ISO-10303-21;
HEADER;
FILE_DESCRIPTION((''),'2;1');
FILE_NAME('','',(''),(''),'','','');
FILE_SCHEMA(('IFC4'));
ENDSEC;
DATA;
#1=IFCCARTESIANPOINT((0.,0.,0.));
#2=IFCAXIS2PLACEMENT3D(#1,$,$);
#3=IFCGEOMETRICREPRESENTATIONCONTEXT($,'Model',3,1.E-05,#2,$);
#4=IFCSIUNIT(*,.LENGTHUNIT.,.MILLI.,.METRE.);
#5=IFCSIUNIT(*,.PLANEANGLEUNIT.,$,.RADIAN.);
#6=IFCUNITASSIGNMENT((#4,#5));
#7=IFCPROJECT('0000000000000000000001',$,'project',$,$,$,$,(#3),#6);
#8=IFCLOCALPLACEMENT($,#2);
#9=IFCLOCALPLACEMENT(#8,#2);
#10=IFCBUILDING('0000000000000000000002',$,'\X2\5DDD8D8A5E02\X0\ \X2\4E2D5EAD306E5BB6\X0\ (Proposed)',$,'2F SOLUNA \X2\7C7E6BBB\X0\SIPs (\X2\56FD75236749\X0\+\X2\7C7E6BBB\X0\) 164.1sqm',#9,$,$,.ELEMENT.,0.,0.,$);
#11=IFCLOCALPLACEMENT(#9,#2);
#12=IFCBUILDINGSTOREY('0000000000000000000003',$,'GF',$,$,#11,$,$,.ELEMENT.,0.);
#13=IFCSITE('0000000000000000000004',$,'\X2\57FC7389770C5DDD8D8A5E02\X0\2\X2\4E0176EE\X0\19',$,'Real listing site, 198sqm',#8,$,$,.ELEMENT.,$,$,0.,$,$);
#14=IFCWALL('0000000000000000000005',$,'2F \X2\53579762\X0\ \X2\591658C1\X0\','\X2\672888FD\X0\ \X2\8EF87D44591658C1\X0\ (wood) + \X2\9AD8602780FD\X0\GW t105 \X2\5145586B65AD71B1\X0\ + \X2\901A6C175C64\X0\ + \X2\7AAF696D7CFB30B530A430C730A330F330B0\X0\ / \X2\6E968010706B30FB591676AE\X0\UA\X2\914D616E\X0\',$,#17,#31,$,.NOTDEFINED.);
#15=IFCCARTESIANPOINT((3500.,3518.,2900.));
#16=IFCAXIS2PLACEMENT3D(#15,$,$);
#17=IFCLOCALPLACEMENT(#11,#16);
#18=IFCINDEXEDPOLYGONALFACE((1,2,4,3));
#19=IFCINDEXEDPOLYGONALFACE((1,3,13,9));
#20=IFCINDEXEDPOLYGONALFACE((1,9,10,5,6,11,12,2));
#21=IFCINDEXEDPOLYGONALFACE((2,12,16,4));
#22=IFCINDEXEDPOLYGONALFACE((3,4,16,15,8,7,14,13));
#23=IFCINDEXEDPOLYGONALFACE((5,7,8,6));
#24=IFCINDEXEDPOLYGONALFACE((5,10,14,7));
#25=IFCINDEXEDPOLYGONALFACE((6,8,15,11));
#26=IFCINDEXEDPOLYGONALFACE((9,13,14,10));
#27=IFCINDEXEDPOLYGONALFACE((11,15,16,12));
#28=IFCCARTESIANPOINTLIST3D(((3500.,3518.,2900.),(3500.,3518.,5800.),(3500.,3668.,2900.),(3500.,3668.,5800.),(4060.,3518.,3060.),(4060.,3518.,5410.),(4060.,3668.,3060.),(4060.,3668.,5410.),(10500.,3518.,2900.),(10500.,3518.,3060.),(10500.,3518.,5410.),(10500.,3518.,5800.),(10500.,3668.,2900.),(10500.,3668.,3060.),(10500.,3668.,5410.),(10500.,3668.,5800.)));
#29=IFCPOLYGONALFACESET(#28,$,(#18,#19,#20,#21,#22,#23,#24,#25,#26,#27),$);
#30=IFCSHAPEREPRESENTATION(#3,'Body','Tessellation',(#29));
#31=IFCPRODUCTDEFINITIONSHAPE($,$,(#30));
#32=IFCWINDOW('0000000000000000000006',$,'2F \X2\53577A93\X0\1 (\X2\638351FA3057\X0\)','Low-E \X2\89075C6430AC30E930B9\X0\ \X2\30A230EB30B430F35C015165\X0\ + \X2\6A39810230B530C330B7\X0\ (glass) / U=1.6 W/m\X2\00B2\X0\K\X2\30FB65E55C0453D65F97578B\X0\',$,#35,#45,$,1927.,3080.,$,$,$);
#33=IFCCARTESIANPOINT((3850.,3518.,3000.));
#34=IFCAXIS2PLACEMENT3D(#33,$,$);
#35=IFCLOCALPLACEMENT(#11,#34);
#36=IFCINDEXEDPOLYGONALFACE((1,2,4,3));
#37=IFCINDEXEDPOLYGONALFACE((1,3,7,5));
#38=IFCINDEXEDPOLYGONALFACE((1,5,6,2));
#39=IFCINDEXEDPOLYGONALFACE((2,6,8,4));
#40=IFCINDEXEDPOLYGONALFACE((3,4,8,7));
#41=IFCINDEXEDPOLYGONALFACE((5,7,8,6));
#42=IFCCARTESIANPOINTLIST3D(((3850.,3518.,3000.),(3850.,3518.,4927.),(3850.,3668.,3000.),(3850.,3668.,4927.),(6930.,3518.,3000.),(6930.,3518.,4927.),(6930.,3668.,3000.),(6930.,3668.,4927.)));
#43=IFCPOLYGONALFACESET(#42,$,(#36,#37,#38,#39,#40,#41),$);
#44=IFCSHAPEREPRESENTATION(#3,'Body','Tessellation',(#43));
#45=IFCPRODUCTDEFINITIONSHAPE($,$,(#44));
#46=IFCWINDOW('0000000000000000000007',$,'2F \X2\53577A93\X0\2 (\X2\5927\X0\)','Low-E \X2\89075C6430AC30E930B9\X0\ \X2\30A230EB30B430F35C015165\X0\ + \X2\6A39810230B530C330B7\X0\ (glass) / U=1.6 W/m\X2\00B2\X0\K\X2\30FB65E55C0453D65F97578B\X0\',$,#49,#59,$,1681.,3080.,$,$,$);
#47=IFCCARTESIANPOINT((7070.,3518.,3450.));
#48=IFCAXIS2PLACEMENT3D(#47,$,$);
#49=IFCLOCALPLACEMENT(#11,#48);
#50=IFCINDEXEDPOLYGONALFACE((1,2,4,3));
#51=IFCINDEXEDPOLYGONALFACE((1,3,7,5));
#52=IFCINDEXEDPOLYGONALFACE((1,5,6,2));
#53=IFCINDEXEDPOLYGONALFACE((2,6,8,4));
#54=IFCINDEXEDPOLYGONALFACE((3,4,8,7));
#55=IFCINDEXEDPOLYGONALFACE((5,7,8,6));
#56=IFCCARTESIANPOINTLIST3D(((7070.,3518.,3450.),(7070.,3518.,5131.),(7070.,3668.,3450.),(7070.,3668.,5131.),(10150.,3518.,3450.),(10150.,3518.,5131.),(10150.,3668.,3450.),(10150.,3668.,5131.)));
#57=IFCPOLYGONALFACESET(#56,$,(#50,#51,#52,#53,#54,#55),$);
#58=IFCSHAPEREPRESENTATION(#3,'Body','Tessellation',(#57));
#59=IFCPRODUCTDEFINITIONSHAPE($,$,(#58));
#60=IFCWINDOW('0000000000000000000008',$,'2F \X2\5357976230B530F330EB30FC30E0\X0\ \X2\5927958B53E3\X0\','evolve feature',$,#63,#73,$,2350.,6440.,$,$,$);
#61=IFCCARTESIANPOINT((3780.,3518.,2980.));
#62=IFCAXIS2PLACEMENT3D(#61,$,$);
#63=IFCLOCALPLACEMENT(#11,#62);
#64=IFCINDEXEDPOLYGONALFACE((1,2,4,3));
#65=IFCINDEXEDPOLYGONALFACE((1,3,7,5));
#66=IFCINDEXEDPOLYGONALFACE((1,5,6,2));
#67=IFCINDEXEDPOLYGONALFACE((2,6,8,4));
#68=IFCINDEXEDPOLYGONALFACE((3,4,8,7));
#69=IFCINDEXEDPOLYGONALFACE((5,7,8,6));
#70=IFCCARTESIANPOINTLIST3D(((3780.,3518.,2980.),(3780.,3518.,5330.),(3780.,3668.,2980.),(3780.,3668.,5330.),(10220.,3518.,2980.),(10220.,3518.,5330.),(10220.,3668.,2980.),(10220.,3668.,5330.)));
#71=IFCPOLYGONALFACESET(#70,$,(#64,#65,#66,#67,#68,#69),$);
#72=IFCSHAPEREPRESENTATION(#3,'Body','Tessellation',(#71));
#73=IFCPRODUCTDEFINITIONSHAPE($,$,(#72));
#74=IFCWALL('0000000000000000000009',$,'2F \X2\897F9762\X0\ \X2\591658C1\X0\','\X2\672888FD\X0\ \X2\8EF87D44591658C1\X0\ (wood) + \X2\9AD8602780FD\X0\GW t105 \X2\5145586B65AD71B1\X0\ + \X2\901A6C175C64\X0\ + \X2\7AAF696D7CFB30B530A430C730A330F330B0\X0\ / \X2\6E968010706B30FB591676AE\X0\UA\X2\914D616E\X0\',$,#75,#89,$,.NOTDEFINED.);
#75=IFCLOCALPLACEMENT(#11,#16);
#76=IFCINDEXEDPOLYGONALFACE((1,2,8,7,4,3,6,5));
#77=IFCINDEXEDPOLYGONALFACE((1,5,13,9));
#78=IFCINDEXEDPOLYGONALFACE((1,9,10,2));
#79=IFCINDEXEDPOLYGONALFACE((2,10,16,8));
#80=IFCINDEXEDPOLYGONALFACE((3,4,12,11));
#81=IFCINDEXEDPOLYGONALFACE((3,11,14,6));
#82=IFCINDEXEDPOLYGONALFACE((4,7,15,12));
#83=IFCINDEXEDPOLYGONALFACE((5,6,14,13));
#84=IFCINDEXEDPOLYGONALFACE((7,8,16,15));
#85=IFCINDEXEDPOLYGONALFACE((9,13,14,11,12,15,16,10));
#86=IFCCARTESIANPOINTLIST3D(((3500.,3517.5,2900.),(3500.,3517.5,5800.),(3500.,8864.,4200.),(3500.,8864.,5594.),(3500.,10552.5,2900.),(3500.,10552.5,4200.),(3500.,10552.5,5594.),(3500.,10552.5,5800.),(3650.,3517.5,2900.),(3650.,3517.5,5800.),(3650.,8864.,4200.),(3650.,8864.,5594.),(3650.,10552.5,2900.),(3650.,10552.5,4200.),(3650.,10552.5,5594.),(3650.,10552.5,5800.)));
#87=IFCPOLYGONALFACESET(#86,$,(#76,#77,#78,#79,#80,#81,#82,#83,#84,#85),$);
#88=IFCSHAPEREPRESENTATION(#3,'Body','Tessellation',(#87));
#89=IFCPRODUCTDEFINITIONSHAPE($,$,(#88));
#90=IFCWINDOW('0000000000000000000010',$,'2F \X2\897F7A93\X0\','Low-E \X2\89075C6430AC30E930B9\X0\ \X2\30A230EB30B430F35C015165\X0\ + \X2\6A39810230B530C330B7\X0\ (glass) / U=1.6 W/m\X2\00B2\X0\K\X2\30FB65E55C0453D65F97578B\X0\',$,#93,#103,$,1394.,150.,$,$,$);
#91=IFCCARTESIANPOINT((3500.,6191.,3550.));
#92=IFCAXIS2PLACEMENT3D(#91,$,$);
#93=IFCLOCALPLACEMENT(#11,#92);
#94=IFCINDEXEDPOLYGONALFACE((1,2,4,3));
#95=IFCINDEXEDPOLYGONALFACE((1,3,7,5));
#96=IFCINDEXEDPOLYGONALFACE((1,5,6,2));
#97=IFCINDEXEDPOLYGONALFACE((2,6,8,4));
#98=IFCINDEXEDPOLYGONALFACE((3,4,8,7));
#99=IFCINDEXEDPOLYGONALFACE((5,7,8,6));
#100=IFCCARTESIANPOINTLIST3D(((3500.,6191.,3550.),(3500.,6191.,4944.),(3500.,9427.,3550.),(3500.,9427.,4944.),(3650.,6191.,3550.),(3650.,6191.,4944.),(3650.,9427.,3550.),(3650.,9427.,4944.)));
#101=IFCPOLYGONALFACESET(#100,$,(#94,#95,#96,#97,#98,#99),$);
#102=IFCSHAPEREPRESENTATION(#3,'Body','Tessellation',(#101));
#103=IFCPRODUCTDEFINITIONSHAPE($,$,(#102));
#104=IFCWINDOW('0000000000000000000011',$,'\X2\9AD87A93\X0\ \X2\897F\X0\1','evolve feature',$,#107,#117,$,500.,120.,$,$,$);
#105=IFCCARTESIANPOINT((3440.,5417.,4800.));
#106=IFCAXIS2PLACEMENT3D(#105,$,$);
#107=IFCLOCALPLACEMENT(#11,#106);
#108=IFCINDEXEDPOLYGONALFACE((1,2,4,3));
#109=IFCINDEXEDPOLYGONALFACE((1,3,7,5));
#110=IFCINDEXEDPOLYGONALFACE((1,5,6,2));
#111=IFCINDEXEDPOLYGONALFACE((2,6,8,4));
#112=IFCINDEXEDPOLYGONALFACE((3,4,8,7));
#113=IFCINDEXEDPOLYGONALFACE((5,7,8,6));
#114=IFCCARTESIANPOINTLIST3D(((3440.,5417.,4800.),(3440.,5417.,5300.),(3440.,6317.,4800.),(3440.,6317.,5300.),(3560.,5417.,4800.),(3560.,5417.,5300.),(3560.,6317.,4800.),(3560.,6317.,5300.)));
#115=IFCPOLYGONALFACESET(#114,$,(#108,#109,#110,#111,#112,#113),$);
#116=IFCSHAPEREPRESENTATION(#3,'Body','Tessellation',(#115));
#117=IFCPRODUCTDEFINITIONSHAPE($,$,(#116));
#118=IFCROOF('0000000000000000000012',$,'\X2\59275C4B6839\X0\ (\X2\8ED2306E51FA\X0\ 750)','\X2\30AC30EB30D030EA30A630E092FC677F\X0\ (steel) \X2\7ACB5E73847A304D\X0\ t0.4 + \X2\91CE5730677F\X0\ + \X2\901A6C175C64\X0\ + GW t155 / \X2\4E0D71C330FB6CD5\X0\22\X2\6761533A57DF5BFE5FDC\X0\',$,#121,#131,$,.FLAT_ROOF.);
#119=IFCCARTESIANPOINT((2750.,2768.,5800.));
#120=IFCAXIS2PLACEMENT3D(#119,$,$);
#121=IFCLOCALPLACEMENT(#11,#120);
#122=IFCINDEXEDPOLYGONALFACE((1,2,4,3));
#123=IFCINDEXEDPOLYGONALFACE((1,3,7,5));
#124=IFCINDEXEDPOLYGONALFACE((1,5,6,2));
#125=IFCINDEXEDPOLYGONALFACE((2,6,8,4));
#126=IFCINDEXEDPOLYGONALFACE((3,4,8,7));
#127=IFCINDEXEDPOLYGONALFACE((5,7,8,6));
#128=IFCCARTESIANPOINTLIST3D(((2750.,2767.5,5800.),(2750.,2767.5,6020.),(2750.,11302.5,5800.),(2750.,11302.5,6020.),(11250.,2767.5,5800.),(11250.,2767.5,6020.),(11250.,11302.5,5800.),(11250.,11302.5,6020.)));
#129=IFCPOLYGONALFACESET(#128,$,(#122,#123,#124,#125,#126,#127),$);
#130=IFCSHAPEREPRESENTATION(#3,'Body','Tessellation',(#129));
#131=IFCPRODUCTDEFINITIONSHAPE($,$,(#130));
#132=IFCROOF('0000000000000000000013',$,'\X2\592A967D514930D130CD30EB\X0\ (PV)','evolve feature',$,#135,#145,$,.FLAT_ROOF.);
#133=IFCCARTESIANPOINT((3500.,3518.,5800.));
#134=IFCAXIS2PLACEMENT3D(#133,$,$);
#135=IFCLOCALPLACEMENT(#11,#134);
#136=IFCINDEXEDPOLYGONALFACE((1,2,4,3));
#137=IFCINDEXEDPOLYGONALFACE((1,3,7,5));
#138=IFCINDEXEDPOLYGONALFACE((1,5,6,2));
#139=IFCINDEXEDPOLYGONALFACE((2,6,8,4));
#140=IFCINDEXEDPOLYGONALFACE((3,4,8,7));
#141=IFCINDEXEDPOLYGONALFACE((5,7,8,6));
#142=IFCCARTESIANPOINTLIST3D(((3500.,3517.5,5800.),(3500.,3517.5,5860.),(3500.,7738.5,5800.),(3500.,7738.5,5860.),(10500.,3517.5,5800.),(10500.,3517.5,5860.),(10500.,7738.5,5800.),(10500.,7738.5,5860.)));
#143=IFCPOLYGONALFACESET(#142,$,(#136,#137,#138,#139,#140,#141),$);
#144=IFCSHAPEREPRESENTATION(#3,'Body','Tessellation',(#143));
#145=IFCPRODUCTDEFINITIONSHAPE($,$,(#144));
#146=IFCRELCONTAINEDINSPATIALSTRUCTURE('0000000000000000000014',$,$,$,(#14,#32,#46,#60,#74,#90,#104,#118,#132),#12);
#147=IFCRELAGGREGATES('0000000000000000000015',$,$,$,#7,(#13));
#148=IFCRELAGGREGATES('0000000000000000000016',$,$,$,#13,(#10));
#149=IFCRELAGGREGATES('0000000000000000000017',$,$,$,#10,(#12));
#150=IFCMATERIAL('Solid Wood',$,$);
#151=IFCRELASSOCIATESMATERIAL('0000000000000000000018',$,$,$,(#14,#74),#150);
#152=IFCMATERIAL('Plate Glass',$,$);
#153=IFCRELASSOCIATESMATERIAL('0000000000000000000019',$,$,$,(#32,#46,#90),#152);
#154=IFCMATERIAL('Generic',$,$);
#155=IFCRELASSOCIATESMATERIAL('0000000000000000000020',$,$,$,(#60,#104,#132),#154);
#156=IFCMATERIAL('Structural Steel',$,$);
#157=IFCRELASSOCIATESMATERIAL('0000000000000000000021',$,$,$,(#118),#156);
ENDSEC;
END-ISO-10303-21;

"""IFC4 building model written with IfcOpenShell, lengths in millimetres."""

from ifc_helpers import new_model, si_unit, frame, frame_2d, origin, place, context, project, spatial, rectangle, extrude, material, element, fill, save


model = new_model("IFC4")

# Units and contexts
model_context = context("Model", 3, precision=1e-05, world=origin())
ifc_project = project(units=[si_unit("LENGTHUNIT", "METRE", prefix="MILLI"), si_unit("PLANEANGLEUNIT", "RADIAN")], contexts=[model_context])

# Site, building, storey
site_placement = place(None, origin())
site = spatial("IfcSite", under=ifc_project, at=site_placement, Name="埼玉県川越市2丁目19", ObjectType="Real listing site, 198sqm", CompositionType="ELEMENT", RefElevation=0.0)
building_placement = place(site_placement, origin())
building = spatial("IfcBuilding", under=site, at=building_placement, Name="川越市 中庭の家 (Proposed)", ObjectType="2F SOLUNA 籾殻SIPs (国産杉+籾殻) 164.1sqm", CompositionType="ELEMENT", ElevationOfRefHeight=0.0, ElevationOfTerrain=0.0)
storey_placement = place(building_placement, origin())
storey = spatial("IfcBuildingStorey", under=building, at=storey_placement, Name="GF", CompositionType="ELEMENT", Elevation=0.0)

# Shared definitions
ifc_material_1 = material(Name="Solid Wood")
ifc_material_2 = material(Name="Generic")

# Shared definitions
ifc_material_3 = material(Name="Plate Glass")

# Walls, openings, windows
wall_1_placement = place(storey_placement, frame((3500.0, 3518.0, 2900.0)))
wall_1 = element("IfcWall", 1, at=wall_1_placement, inside=storey, material=ifc_material_1, Name="2F 南面 外壁", Description="木製 軸組外壁 (wood) + 高性能GW t105 充填断熱 + 通気層 + 窯業系サイディング / 準耐火・外皮UA配慮", PredefinedType="NOTDEFINED", context=model_context, shape_type="SweptSolid", body=[
    extrude(rectangle(XDim=7000.0, YDim=150.0, at=frame_2d((3500.0, 75.0))), frame((3500.0, 3518.0, 2900.0)), (0.0, 0.0, 1.0), 2900.0),
])
opening_1_placement = place(storey_placement, frame((3850.0, 3518.0, 3000.0)))
opening_1 = element("IfcOpeningElement", 2, at=opening_1_placement, cuts=wall_1, PredefinedType="NOTDEFINED", context=model_context, shape_type="SweptSolid", body=[
    extrude(rectangle(XDim=3080.0, YDim=150.0, at=frame_2d((1540.0, 75.0))), frame((3850.0, 3518.0, 3000.0)), (0.0, 0.0, 1.0), 1927.0),
])
opening_2_placement = place(storey_placement, frame((7070.0, 3518.0, 3450.0)))
opening_2 = element("IfcOpeningElement", 3, at=opening_2_placement, cuts=wall_1, PredefinedType="NOTDEFINED", context=model_context, shape_type="SweptSolid", body=[
    extrude(rectangle(XDim=3080.0, YDim=150.0, at=frame_2d((1540.0, 75.0))), frame((7070.0, 3518.0, 3450.0)), (0.0, 0.0, 1.0), 1681.0),
])
opening_3_placement = place(storey_placement, frame((3780.0, 3518.0, 2980.0)))
opening_3 = element("IfcOpeningElement", 4, at=opening_3_placement, cuts=wall_1, PredefinedType="NOTDEFINED", context=model_context, shape_type="SweptSolid", body=[
    extrude(rectangle(XDim=6440.0, YDim=150.0, at=frame_2d((3220.0, 75.0))), frame((3780.0, 3518.0, 2980.0)), (0.0, 0.0, 1.0), 2350.0),
])
window_1_placement = place(storey_placement, frame((3850.0, 3518.0, 3000.0)))
window_1 = element("IfcWindow", 5, at=window_1_placement, inside=storey, material=ifc_material_3, Name="2F 南窓1 (掃出し)", Description="Low-E 複層ガラス アルゴン封入 + 樹脂サッシ (glass) / U=1.6 W/m²K・日射取得型", OverallHeight=1927.0, OverallWidth=3080.0, context=model_context, shape_type="SweptSolid", body=[
    extrude(rectangle(XDim=3080.0, YDim=150.0, at=frame_2d((1540.0, 75.0))), frame((3850.0, 3518.0, 3000.0)), (0.0, 0.0, 1.0), 1927.0),
])
fill(opening_1, window_1)
window_2_placement = place(storey_placement, frame((7070.0, 3518.0, 3450.0)))
window_2 = element("IfcWindow", 6, at=window_2_placement, inside=storey, material=ifc_material_3, Name="2F 南窓2 (大)", Description="Low-E 複層ガラス アルゴン封入 + 樹脂サッシ (glass) / U=1.6 W/m²K・日射取得型", OverallHeight=1681.0, OverallWidth=3080.0, context=model_context, shape_type="SweptSolid", body=[
    extrude(rectangle(XDim=3080.0, YDim=150.0, at=frame_2d((1540.0, 75.0))), frame((7070.0, 3518.0, 3450.0)), (0.0, 0.0, 1.0), 1681.0),
])
fill(opening_2, window_2)
window_3_placement = place(storey_placement, frame((3780.0, 3518.0, 2980.0)))
window_3 = element("IfcWindow", 7, at=window_3_placement, inside=storey, material=ifc_material_2, Name="2F 南面サンルーム 大開口", Description="evolve feature", OverallHeight=2350.0, OverallWidth=6440.0, context=model_context, shape_type="SweptSolid", body=[
    extrude(rectangle(XDim=6440.0, YDim=150.0, at=frame_2d((3220.0, 75.0))), frame((3780.0, 3518.0, 2980.0)), (0.0, 0.0, 1.0), 2350.0),
])
fill(opening_3, window_3)
wall_2_placement = place(storey_placement, frame((3500.0, 3518.0, 2900.0)))
wall_2 = element("IfcWall", 8, at=wall_2_placement, inside=storey, material=ifc_material_1, Name="2F 西面 外壁", Description="木製 軸組外壁 (wood) + 高性能GW t105 充填断熱 + 通気層 + 窯業系サイディング / 準耐火・外皮UA配慮", PredefinedType="NOTDEFINED", context=model_context, shape_type="SweptSolid", body=[
    extrude(rectangle(XDim=150.0, YDim=7035.0, at=frame_2d((75.0, 3517.0))), frame((3500.0, 3518.0, 2900.0)), (0.0, 0.0, 1.0), 2900.0),
])
opening_4_placement = place(storey_placement, frame((3500.0, 6191.0, 3550.0)))
opening_4 = element("IfcOpeningElement", 9, at=opening_4_placement, cuts=wall_2, PredefinedType="NOTDEFINED", context=model_context, shape_type="SweptSolid", body=[
    extrude(rectangle(XDim=150.0, YDim=3236.0, at=frame_2d((75.0, 1618.0))), frame((3500.0, 6191.0, 3550.0)), (0.0, 0.0, 1.0), 1394.0),
])
opening_5_placement = place(storey_placement, frame((3440.0, 5417.0, 4800.0)))
opening_5 = element("IfcOpeningElement", 10, at=opening_5_placement, cuts=wall_2, PredefinedType="NOTDEFINED", context=model_context, shape_type="SweptSolid", body=[
    extrude(rectangle(XDim=120.0, YDim=900.0, at=frame_2d((60.0, 450.0))), frame((3440.0, 5417.0, 4800.0)), (0.0, 0.0, 1.0), 500.0),
])
window_4_placement = place(storey_placement, frame((3500.0, 6191.0, 3550.0)))
window_4 = element("IfcWindow", 11, at=window_4_placement, inside=storey, material=ifc_material_3, Name="2F 西窓", Description="Low-E 複層ガラス アルゴン封入 + 樹脂サッシ (glass) / U=1.6 W/m²K・日射取得型", OverallHeight=1394.0, OverallWidth=150.0, context=model_context, shape_type="SweptSolid", body=[
    extrude(rectangle(XDim=150.0, YDim=3236.0, at=frame_2d((75.0, 1618.0))), frame((3500.0, 6191.0, 3550.0)), (0.0, 0.0, 1.0), 1394.0),
])
fill(opening_4, window_4)
window_5_placement = place(storey_placement, frame((3440.0, 5417.0, 4800.0)))
window_5 = element("IfcWindow", 12, at=window_5_placement, inside=storey, material=ifc_material_2, Name="高窓 西1", Description="evolve feature", OverallHeight=500.0, OverallWidth=120.0, context=model_context, shape_type="SweptSolid", body=[
    extrude(rectangle(XDim=120.0, YDim=900.0, at=frame_2d((60.0, 450.0))), frame((3440.0, 5417.0, 4800.0)), (0.0, 0.0, 1.0), 500.0),
])
fill(opening_5, window_5)

# Roofs
ifc_material_4 = material(Name="Structural Steel")
roof_1_placement = place(storey_placement, frame((2750.0, 2768.0, 5800.0)))
element("IfcRoof", 13, at=roof_1_placement, inside=storey, material=ifc_material_4, Name="大屋根 (軒の出 750)", Description="ガルバリウム鋼板 (steel) 立平葺き t0.4 + 野地板 + 通気層 + GW t155 / 不燃・法22条区域対応", PredefinedType="FLAT_ROOF", context=model_context, shape_type="SweptSolid", body=[
    extrude(rectangle(XDim=8500.0, YDim=8535.0, at=frame_2d((4250.0, 4267.0))), frame((2750.0, 2768.0, 5800.0)), (0.0, 0.0, 1.0), 220.0),
])
roof_2_placement = place(storey_placement, frame((3500.0, 3518.0, 5800.0)))
element("IfcRoof", 14, at=roof_2_placement, inside=storey, material=ifc_material_2, Name="太陽光パネル (PV)", Description="evolve feature", PredefinedType="FLAT_ROOF", context=model_context, shape_type="SweptSolid", body=[
    extrude(rectangle(XDim=7000.0, YDim=4221.0, at=frame_2d((3500.0, 2110.0))), frame((3500.0, 3518.0, 5800.0)), (0.0, 0.0, 1.0), 60.0),
])

save(model, "model.ifc")
